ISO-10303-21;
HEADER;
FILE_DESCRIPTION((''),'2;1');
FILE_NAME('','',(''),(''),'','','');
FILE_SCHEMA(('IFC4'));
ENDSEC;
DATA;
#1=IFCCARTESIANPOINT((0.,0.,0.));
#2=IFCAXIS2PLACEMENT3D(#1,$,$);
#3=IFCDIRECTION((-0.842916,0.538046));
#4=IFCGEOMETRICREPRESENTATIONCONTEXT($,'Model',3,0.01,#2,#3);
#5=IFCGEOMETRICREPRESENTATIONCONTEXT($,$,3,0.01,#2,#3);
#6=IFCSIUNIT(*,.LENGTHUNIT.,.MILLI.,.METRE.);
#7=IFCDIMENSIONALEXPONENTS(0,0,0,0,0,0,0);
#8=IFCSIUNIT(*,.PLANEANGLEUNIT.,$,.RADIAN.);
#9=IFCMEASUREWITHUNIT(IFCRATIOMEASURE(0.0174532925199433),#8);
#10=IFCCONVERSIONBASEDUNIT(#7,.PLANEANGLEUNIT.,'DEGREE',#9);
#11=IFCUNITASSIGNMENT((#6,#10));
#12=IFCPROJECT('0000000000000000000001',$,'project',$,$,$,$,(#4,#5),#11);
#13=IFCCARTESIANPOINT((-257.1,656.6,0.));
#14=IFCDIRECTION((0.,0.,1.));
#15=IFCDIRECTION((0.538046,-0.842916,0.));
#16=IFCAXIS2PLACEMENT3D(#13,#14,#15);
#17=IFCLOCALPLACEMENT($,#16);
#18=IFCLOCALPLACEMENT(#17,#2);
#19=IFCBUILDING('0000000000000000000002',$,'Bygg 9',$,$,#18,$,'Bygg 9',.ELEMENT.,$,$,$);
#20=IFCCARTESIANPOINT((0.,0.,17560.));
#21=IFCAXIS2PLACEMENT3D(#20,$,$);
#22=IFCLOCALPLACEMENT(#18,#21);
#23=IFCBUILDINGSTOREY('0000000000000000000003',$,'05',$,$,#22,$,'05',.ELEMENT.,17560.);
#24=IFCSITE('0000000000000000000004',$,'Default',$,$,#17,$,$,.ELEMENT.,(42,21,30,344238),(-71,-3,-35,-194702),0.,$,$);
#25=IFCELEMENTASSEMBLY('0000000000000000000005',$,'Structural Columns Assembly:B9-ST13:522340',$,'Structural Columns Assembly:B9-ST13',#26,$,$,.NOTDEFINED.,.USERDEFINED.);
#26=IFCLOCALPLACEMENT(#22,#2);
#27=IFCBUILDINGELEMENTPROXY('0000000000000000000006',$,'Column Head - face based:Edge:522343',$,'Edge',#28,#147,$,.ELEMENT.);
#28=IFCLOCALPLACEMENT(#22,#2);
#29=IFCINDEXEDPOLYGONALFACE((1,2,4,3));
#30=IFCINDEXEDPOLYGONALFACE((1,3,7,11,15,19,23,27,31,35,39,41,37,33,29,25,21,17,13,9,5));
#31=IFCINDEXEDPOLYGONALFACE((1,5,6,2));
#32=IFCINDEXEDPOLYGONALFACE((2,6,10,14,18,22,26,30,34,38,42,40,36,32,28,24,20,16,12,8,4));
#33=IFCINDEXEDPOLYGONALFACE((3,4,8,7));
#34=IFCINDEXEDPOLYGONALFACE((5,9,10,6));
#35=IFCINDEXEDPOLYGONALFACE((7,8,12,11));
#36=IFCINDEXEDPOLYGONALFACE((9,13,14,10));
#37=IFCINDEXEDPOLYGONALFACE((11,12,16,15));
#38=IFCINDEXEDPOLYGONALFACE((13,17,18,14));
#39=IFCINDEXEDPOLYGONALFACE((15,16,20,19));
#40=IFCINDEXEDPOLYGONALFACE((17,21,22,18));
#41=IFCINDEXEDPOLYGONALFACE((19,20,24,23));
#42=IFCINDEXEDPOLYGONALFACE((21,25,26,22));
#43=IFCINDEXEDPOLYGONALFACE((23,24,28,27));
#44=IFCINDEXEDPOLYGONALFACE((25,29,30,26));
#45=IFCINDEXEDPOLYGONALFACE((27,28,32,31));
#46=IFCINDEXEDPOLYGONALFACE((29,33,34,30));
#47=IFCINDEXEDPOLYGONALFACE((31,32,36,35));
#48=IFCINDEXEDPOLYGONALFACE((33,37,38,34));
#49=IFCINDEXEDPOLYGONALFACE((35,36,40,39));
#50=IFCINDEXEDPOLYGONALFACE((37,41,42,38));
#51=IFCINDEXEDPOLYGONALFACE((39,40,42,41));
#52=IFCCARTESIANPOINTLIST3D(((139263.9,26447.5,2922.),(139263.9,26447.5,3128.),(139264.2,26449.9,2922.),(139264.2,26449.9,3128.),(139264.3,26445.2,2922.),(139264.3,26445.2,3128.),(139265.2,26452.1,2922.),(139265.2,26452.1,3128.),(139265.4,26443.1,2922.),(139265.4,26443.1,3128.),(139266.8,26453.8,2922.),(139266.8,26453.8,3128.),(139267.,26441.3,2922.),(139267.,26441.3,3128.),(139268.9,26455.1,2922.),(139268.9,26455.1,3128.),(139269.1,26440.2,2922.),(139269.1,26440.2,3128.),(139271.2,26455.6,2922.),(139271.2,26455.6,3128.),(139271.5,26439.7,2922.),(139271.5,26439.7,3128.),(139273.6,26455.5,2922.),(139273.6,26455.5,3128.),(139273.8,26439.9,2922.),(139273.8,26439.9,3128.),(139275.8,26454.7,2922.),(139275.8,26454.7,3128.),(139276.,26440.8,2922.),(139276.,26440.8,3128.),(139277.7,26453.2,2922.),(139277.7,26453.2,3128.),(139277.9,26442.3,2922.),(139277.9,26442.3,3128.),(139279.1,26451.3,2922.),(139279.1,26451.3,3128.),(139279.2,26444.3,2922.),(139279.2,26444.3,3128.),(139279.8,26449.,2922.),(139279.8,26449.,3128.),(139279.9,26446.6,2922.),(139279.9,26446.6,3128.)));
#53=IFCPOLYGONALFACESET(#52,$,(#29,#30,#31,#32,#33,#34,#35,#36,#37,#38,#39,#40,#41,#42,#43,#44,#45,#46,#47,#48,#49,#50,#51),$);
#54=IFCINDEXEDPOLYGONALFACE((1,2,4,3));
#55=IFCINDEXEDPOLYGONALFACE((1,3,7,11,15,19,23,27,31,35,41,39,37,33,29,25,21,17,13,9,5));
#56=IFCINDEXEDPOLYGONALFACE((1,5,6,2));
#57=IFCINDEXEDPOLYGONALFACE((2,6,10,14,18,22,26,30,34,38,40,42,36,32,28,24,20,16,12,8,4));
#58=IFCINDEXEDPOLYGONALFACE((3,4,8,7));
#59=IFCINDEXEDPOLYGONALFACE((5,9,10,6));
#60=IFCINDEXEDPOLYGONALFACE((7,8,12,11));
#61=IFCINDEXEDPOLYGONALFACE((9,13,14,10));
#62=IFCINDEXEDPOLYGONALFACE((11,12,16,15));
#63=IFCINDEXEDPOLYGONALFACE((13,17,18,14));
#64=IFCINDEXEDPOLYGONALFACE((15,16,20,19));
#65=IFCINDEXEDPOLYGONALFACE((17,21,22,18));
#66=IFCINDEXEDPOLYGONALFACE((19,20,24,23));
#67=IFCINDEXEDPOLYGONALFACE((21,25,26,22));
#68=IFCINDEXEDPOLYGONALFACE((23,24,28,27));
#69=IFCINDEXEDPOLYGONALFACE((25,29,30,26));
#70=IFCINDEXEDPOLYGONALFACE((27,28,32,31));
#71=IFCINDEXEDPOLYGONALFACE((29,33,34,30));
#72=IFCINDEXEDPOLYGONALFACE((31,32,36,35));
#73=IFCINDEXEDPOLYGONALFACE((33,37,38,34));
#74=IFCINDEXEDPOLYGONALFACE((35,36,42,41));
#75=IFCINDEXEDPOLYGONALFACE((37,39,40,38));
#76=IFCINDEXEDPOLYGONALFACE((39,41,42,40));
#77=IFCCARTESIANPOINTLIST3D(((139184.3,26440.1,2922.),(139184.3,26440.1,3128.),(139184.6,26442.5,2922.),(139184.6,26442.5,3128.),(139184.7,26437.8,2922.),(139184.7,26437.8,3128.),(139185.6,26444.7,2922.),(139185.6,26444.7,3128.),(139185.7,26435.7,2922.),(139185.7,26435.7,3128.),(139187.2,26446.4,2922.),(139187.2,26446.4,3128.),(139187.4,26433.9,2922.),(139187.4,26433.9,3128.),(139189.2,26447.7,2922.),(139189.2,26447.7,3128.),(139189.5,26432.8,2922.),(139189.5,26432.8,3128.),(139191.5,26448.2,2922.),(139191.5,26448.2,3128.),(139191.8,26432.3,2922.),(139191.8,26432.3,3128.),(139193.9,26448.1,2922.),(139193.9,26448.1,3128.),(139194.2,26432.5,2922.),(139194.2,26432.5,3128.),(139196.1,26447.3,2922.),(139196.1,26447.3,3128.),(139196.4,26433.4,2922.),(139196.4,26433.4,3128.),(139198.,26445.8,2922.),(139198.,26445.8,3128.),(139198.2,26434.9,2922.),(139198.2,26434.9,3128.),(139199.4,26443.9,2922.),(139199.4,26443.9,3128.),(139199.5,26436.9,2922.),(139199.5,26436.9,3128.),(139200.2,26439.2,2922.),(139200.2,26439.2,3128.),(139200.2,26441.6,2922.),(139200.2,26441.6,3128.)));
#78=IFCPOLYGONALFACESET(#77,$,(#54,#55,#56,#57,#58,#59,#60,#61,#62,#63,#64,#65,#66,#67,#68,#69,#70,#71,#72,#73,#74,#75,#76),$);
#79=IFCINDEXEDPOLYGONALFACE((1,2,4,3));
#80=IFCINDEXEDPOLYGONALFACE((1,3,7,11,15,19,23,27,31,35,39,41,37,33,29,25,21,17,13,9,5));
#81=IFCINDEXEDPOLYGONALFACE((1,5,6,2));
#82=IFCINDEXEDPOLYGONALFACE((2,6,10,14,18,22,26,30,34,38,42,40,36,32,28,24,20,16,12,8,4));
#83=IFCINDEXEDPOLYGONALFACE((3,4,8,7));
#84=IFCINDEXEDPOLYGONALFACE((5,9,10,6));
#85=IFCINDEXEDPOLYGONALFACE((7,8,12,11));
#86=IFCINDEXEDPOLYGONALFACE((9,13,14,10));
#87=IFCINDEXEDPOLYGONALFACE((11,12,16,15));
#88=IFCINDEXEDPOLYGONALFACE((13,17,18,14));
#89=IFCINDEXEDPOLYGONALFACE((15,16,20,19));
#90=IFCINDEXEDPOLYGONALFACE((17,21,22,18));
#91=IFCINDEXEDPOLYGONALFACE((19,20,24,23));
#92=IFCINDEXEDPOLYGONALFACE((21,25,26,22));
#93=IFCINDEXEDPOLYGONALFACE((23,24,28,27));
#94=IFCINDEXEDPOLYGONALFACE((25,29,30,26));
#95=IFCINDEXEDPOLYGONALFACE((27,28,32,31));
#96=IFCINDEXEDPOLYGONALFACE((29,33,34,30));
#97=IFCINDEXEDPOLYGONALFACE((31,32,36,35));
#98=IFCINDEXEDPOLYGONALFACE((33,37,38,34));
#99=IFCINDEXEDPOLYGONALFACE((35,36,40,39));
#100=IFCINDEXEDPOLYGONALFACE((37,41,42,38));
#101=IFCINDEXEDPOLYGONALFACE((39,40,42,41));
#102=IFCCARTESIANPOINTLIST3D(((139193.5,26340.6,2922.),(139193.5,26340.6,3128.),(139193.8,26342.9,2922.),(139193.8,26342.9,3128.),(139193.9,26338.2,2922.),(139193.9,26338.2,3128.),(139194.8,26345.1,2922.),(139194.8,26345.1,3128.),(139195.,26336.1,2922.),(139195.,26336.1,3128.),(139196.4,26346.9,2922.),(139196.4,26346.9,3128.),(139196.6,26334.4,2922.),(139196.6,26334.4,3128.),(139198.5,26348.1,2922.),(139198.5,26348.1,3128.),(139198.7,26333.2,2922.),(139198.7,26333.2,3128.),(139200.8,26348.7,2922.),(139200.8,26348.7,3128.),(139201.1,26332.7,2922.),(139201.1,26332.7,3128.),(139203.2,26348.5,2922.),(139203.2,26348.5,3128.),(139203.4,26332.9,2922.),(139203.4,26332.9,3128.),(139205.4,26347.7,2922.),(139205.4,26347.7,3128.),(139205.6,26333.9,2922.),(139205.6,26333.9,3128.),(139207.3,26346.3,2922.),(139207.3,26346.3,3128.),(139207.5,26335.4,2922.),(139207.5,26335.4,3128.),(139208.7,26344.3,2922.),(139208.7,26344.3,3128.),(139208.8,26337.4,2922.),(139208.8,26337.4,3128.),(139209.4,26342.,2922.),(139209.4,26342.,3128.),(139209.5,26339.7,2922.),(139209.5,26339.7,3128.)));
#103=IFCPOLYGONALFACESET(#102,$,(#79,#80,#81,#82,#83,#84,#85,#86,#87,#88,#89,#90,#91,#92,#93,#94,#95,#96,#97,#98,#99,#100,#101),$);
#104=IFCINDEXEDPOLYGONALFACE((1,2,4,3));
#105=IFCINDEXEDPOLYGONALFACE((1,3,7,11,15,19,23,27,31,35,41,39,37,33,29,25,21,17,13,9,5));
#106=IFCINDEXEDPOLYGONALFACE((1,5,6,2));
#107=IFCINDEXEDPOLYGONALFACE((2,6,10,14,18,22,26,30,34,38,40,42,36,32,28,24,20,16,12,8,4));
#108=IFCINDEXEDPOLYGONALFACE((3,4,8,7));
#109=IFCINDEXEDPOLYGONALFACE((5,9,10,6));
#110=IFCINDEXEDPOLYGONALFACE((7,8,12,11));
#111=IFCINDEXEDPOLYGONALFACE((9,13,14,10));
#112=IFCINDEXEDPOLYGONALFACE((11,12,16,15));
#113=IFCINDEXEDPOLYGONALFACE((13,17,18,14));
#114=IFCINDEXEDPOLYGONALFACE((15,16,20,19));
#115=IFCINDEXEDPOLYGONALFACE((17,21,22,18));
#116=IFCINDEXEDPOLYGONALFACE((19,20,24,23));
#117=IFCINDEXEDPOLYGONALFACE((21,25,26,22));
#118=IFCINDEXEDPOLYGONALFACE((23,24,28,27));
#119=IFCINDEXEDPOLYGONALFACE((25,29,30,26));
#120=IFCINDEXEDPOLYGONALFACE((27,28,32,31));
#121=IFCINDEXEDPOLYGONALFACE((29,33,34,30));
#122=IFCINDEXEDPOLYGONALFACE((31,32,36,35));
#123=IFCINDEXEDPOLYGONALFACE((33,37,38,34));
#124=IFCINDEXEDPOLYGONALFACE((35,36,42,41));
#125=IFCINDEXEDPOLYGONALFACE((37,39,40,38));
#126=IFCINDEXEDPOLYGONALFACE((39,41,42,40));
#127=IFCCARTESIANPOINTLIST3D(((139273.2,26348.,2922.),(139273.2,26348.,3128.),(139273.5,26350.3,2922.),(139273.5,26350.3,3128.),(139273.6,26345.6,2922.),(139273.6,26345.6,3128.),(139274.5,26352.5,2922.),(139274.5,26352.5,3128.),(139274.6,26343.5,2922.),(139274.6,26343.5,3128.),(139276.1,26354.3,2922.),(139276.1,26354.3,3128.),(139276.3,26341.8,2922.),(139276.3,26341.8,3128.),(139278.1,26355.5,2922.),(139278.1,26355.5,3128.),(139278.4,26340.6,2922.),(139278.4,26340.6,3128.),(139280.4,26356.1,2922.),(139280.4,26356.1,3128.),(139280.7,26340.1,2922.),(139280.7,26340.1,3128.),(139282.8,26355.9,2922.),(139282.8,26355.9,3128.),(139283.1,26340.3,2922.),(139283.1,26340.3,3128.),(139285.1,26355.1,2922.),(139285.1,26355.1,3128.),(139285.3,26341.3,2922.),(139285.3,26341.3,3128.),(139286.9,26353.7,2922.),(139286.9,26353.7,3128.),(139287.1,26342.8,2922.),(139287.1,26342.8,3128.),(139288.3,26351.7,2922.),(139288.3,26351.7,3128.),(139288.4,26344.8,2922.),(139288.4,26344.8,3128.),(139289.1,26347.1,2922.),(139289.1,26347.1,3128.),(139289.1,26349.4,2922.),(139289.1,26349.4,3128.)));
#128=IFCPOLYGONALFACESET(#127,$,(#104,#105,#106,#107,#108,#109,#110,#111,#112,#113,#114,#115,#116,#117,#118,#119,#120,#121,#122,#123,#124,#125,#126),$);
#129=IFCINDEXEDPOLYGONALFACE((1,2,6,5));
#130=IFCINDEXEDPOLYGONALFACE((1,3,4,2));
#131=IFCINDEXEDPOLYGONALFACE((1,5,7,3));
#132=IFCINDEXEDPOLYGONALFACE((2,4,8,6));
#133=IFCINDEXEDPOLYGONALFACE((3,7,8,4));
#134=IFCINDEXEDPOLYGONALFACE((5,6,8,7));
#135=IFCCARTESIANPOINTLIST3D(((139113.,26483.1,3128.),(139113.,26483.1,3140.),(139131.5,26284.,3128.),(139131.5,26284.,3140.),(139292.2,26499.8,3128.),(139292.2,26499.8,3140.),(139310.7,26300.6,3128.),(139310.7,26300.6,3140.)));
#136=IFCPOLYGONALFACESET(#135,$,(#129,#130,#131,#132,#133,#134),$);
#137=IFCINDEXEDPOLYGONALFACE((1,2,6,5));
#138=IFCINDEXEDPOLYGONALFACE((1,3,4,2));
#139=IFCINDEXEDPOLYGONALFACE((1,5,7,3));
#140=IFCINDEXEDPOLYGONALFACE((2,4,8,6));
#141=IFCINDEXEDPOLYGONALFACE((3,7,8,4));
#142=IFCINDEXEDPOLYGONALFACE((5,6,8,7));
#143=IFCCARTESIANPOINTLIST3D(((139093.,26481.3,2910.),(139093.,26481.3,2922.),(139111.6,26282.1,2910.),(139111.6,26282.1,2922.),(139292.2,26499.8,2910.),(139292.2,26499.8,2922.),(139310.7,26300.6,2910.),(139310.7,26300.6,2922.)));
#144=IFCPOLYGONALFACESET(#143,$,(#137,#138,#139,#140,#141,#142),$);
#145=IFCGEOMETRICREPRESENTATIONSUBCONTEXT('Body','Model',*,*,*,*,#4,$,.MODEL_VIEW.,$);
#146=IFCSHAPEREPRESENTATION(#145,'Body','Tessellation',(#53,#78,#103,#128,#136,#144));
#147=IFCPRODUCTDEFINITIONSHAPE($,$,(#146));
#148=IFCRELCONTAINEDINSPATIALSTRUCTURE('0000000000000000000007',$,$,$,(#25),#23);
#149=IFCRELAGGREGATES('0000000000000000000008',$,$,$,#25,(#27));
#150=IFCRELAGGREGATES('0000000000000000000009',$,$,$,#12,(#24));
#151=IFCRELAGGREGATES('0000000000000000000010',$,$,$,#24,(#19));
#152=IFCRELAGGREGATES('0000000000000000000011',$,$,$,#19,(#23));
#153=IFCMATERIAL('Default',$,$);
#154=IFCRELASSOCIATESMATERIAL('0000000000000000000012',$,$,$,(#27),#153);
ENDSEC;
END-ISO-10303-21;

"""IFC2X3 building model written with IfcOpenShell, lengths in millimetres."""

from ifc_helpers import new_model, entity, si_unit, converted_unit, direction, frame, frame_2d, origin, origin_2d_with_axis, place, context, subcontext, project, spatial, rectangle, circle, extrude, source, transform, mapped, material, element, aggregate, save


model = new_model("IFC2X3")

# Units and contexts
model_context = context("Model", 3, precision=0.01, world=origin(), true_north=direction((-0.842916, 0.538046)))
context_of_model = context(None, 3, precision=0.01, world=origin(), true_north=direction((-0.842916, 0.538046)))
body_context = subcontext(model_context, "Body", "Model", "MODEL_VIEW")
ifc_project = project(units=[si_unit("LENGTHUNIT", "METRE", prefix="MILLI"), converted_unit("PLANEANGLEUNIT", "DEGREE", entity("IfcRatioMeasure", 0.0174532925199433), si_unit("PLANEANGLEUNIT", "RADIAN"), dimensions=[0, 0, 0, 0, 0, 0, 0])], contexts=[model_context, context_of_model])

# Site, building, storey
site_placement = place(None, frame((-257.1, 656.6, 0.0), z_axis=(0.0, 0.0, 1.0), x_axis=(0.538046, -0.842916, 0.0)))
site = spatial("IfcSite", under=ifc_project, at=site_placement, Name="Default", CompositionType="ELEMENT", RefLatitude=(42, 21, 30, 344238), RefLongitude=(-71, -3, -35, -194702), RefElevation=0.0)
building_placement = place(site_placement, origin())
building = spatial("IfcBuilding", under=site, at=building_placement, Name="Bygg 9", LongName="Bygg 9", CompositionType="ELEMENT")
storey_placement = place(building_placement, frame((0.0, 0.0, 17560.0)))
storey = spatial("IfcBuildingStorey", under=building, at=storey_placement, Name="05", LongName="05", CompositionType="ELEMENT", Elevation=17560.0)

# Shared definitions
ifc_material_1 = material(Name="Default")

# Element assembly, building element proxy
shared_shape_1 = source(origin(), body_context, "Body", "SweptSolid", [
    extrude(circle(Radius=8.0, at=frame_2d((0.0, 0.0), x_axis=(1.0, 0.0))), frame((50.0, -135.0, 12.0)), (0.0, 0.0, 1.0), 206.0),
    extrude(circle(Radius=8.0, at=frame_2d((0.0, 0.0), x_axis=(1.0, 0.0))), frame((50.0, -55.0, 12.0)), (0.0, 0.0, 1.0), 206.0),
    extrude(circle(Radius=8.0, at=frame_2d((0.0, 0.0), x_axis=(1.0, 0.0))), frame((-50.0, -55.0, 12.0)), (0.0, 0.0, 1.0), 206.0),
    extrude(circle(Radius=8.0, at=frame_2d((0.0, 0.0), x_axis=(1.0, 0.0))), frame((-50.0, -135.0, 12.0)), (0.0, 0.0, 1.0), 206.0),
    extrude(rectangle(XDim=200.0, YDim=180.0, at=origin_2d_with_axis()), frame((0.0, -70.0, 218.0), z_axis=(0.0, 0.0, 1.0), x_axis=(-1.0, 0.0, 0.0)), (0.0, 0.0, 1.0), 12.0),
    extrude(rectangle(XDim=200.0, YDim=200.0, at=origin_2d_with_axis()), frame((0.0, -60.0, 0.0), z_axis=(0.0, 0.0, 1.0), x_axis=(0.0, 1.0, 0.0)), (0.0, 0.0, 1.0), 12.0),
])
assembly_1_placement = place(storey_placement, origin())
assembly_1 = element("IfcElementAssembly", 1, at=assembly_1_placement, inside=storey, Name="Structural Columns Assembly:B9-ST13:522340", ObjectType="Structural Columns Assembly:B9-ST13", AssemblyPlace="NOTDEFINED", PredefinedType="USERDEFINED")
proxy_1_placement = place(assembly_1_placement, frame((139142.1, 26385.4, 2910.0), z_axis=(0.0, 0.0, 1.0), x_axis=(-0.092535, 0.995709, 0.0)))
proxy_1 = element("IfcBuildingElementProxy", 2, at=proxy_1_placement, material=ifc_material_1, Name="Column Head - face based:Edge:522343", ObjectType="Edge", CompositionType="ELEMENT", context=body_context, shape_type="MappedRepresentation", body=[
    mapped(shared_shape_1, transform((0.0, 0.0, 0.0), scale=1.0)),
])
aggregate(assembly_1, [proxy_1])

save(model, "model.ifc")
